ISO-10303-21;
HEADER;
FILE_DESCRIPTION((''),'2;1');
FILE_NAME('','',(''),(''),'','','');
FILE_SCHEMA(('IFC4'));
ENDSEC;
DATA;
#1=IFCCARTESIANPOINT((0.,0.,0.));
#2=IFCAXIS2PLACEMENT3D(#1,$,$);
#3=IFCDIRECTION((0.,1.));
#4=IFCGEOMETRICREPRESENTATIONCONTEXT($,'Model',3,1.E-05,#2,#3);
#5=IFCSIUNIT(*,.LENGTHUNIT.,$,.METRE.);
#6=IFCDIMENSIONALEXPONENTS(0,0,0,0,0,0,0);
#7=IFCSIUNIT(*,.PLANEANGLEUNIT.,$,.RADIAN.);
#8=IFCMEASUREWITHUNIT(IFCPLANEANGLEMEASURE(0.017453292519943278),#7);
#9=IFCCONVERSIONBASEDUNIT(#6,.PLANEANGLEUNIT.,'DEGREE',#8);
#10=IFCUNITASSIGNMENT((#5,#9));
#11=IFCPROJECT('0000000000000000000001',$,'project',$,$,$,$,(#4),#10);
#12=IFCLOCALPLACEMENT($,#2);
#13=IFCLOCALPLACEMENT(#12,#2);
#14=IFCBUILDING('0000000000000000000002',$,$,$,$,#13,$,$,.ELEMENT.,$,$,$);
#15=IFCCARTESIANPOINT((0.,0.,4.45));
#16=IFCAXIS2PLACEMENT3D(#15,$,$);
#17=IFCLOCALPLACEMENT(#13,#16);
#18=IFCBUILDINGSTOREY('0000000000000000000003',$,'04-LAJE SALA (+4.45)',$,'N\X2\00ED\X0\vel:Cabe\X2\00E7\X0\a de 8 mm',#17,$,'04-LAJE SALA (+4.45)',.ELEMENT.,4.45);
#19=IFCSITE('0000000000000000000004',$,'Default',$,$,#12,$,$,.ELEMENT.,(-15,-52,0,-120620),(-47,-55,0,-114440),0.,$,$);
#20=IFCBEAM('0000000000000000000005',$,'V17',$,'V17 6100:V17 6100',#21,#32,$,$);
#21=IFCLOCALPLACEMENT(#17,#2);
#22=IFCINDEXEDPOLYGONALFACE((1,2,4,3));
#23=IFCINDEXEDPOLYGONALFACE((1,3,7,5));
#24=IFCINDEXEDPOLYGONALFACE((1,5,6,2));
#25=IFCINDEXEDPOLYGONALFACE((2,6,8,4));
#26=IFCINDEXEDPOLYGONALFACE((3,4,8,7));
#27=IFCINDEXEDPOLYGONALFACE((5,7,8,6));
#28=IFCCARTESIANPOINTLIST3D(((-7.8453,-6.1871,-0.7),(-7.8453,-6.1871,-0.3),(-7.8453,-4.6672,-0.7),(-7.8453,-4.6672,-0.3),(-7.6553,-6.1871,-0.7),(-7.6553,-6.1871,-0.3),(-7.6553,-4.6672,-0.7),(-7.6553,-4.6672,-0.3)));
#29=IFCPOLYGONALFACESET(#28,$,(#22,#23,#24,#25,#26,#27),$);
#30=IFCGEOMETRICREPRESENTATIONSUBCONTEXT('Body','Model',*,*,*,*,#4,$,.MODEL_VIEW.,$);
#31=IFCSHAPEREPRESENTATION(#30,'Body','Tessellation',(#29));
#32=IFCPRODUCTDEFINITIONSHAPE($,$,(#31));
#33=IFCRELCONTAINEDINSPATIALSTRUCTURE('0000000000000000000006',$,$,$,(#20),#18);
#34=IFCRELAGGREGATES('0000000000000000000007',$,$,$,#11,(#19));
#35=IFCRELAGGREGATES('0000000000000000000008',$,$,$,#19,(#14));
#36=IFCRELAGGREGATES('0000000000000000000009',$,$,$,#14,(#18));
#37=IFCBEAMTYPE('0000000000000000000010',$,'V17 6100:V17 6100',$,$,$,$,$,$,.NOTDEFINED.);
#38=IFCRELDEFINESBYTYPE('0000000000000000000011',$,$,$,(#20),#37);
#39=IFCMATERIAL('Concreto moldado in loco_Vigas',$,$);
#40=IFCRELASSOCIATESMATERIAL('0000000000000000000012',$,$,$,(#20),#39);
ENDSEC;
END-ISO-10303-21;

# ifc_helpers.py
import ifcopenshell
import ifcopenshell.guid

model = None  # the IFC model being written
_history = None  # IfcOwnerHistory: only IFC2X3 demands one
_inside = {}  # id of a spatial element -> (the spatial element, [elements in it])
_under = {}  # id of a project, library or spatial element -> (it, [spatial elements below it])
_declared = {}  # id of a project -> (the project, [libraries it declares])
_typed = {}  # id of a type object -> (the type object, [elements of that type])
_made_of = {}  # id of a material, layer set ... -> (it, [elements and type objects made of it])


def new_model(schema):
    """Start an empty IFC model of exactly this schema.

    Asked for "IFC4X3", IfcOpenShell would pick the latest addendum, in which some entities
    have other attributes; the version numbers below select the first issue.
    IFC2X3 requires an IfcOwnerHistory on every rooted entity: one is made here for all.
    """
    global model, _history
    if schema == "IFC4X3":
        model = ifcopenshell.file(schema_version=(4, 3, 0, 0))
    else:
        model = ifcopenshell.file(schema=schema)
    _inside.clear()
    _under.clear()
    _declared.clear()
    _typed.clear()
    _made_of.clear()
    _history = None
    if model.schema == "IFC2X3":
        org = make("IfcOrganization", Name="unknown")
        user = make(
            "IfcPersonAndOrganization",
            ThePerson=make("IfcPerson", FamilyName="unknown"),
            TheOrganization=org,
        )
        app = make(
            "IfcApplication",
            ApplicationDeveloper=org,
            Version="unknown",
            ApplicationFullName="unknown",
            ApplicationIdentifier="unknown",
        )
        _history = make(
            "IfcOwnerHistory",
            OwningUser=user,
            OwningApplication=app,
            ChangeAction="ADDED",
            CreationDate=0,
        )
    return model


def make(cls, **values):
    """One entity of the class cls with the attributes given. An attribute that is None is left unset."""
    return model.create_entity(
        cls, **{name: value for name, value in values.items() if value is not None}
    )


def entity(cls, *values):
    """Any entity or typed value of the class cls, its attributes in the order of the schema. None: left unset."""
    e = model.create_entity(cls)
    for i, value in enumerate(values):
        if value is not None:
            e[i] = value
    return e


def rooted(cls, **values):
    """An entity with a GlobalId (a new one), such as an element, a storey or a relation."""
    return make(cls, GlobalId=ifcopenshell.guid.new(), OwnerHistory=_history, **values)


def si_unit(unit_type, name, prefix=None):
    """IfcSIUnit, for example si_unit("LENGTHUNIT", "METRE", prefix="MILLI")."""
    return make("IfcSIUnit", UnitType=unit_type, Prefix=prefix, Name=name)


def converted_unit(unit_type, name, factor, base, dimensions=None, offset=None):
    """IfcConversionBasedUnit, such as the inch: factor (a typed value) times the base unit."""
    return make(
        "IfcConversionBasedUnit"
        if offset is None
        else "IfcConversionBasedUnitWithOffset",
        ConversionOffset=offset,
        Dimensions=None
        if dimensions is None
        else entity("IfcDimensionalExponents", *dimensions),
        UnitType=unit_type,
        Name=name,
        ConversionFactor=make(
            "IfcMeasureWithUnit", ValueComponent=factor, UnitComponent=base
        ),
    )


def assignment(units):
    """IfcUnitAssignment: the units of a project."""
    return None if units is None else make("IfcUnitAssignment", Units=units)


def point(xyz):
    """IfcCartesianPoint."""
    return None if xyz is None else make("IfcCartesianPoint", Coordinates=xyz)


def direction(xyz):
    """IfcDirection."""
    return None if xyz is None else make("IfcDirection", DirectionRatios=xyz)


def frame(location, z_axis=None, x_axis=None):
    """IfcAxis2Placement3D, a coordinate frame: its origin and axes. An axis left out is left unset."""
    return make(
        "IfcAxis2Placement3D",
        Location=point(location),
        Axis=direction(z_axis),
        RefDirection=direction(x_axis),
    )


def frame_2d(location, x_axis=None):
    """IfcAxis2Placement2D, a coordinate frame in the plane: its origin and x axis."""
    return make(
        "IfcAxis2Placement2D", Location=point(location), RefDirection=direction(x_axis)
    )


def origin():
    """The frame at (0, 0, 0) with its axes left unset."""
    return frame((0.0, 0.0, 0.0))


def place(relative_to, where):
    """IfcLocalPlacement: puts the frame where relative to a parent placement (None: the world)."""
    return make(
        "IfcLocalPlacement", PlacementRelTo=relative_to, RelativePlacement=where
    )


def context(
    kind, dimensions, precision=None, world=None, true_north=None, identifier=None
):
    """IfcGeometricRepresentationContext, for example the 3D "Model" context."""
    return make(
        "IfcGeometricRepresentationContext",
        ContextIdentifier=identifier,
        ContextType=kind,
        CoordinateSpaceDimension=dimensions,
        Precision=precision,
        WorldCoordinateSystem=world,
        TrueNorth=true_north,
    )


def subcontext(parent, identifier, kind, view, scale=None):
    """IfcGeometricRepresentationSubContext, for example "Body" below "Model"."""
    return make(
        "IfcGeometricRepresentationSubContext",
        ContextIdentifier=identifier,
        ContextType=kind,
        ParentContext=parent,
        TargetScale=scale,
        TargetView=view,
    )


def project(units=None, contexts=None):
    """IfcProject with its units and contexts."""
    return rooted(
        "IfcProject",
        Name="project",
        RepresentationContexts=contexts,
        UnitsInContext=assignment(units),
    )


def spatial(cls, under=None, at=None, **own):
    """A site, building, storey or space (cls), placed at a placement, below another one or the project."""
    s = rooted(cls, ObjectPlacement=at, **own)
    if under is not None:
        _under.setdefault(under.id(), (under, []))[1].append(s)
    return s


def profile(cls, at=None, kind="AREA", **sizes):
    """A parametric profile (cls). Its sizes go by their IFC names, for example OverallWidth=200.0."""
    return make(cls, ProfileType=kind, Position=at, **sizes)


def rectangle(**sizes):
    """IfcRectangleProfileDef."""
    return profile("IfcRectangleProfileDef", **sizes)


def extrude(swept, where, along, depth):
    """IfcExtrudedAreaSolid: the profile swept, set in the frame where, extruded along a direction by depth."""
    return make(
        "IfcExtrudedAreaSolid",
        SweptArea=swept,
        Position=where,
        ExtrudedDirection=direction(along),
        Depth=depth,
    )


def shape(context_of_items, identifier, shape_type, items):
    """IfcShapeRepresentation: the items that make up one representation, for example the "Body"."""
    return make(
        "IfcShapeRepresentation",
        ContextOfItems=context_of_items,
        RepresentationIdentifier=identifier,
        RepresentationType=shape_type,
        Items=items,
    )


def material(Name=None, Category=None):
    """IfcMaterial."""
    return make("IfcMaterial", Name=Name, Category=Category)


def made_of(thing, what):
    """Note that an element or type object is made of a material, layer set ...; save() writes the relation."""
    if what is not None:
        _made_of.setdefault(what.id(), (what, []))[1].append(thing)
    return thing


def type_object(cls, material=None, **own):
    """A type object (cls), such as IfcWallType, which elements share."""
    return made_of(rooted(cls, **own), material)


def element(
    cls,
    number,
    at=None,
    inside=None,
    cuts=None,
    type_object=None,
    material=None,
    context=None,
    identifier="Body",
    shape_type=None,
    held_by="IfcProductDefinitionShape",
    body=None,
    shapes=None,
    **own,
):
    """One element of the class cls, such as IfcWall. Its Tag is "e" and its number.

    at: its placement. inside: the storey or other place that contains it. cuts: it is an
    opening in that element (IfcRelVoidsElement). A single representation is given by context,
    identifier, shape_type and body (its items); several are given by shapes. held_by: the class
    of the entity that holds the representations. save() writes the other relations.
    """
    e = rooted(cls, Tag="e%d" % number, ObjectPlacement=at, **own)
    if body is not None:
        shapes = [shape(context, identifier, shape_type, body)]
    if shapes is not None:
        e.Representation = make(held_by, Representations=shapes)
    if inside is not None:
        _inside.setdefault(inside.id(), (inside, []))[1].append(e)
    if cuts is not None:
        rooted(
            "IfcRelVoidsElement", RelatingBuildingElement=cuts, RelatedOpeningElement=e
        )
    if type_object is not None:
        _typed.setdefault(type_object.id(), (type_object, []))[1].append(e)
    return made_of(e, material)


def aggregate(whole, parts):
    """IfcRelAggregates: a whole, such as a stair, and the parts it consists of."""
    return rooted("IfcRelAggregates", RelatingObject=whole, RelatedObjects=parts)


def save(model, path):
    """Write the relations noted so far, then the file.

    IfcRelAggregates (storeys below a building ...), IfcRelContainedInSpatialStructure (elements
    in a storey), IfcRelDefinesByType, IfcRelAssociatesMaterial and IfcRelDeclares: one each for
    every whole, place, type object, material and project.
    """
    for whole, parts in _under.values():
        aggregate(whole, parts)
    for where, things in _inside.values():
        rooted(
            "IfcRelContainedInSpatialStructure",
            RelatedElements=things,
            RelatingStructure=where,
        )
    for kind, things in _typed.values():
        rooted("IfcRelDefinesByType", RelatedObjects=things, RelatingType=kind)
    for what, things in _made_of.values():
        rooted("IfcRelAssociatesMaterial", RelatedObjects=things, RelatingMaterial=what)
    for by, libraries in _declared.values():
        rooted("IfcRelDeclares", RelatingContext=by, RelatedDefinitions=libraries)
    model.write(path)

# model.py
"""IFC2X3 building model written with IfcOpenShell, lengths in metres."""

from ifc_helpers import new_model, entity, si_unit, converted_unit, direction, frame, frame_2d, origin, place, context, subcontext, project, spatial, rectangle, extrude, material, type_object, element, save


model = new_model("IFC2X3")

# Units and contexts
model_context = context("Model", 3, precision=1e-05, world=origin(), true_north=direction((0.0, 1.0)))
body_context = subcontext(model_context, "Body", "Model", "MODEL_VIEW")
ifc_project = project(units=[si_unit("LENGTHUNIT", "METRE"), converted_unit("PLANEANGLEUNIT", "DEGREE", entity("IfcPlaneAngleMeasure", 0.017453292519943278), si_unit("PLANEANGLEUNIT", "RADIAN"), dimensions=[0, 0, 0, 0, 0, 0, 0])], contexts=[model_context])

# Site, building, storey
site_placement = place(None, origin())
site = spatial("IfcSite", under=ifc_project, at=site_placement, Name="Default", CompositionType="ELEMENT", RefLatitude=(-15, -52, 0, -120620), RefLongitude=(-47, -55, 0, -114440), RefElevation=0.0)
building_placement = place(site_placement, origin())
building = spatial("IfcBuilding", under=site, at=building_placement, CompositionType="ELEMENT")
storey_placement = place(building_placement, frame((0.0, 0.0, 4.45)))
storey = spatial("IfcBuildingStorey", under=building, at=storey_placement, Name="04-LAJE SALA (+4.45)", ObjectType="Nível:Cabeça de 8 mm", LongName="04-LAJE SALA (+4.45)", CompositionType="ELEMENT", Elevation=4.45)

# Beam
ifc_material_1 = material(Name="Concreto moldado in loco_Vigas")
beam_type_1 = type_object("IfcBeamType", Name="V17 6100:V17 6100", PredefinedType="NOTDEFINED")
beam_1_placement = place(storey_placement, origin())
element("IfcBeam", 1, at=beam_1_placement, inside=storey, type_object=beam_type_1, material=ifc_material_1, Name="V17", ObjectType="V17 6100:V17 6100", context=body_context, shape_type="SweptSolid", body=[
    extrude(rectangle(XDim=0.4, YDim=1.5199, at=frame_2d((0.0, 0.0), x_axis=(0.0, 1.0))), frame((-7.8453, -5.4271, -0.5), z_axis=(1.0, 0.0, 0.0), x_axis=(0.0, -1.0, 0.0)), (0.0, 0.0, 1.0), 0.19),
])

save(model, "model.ifc")
